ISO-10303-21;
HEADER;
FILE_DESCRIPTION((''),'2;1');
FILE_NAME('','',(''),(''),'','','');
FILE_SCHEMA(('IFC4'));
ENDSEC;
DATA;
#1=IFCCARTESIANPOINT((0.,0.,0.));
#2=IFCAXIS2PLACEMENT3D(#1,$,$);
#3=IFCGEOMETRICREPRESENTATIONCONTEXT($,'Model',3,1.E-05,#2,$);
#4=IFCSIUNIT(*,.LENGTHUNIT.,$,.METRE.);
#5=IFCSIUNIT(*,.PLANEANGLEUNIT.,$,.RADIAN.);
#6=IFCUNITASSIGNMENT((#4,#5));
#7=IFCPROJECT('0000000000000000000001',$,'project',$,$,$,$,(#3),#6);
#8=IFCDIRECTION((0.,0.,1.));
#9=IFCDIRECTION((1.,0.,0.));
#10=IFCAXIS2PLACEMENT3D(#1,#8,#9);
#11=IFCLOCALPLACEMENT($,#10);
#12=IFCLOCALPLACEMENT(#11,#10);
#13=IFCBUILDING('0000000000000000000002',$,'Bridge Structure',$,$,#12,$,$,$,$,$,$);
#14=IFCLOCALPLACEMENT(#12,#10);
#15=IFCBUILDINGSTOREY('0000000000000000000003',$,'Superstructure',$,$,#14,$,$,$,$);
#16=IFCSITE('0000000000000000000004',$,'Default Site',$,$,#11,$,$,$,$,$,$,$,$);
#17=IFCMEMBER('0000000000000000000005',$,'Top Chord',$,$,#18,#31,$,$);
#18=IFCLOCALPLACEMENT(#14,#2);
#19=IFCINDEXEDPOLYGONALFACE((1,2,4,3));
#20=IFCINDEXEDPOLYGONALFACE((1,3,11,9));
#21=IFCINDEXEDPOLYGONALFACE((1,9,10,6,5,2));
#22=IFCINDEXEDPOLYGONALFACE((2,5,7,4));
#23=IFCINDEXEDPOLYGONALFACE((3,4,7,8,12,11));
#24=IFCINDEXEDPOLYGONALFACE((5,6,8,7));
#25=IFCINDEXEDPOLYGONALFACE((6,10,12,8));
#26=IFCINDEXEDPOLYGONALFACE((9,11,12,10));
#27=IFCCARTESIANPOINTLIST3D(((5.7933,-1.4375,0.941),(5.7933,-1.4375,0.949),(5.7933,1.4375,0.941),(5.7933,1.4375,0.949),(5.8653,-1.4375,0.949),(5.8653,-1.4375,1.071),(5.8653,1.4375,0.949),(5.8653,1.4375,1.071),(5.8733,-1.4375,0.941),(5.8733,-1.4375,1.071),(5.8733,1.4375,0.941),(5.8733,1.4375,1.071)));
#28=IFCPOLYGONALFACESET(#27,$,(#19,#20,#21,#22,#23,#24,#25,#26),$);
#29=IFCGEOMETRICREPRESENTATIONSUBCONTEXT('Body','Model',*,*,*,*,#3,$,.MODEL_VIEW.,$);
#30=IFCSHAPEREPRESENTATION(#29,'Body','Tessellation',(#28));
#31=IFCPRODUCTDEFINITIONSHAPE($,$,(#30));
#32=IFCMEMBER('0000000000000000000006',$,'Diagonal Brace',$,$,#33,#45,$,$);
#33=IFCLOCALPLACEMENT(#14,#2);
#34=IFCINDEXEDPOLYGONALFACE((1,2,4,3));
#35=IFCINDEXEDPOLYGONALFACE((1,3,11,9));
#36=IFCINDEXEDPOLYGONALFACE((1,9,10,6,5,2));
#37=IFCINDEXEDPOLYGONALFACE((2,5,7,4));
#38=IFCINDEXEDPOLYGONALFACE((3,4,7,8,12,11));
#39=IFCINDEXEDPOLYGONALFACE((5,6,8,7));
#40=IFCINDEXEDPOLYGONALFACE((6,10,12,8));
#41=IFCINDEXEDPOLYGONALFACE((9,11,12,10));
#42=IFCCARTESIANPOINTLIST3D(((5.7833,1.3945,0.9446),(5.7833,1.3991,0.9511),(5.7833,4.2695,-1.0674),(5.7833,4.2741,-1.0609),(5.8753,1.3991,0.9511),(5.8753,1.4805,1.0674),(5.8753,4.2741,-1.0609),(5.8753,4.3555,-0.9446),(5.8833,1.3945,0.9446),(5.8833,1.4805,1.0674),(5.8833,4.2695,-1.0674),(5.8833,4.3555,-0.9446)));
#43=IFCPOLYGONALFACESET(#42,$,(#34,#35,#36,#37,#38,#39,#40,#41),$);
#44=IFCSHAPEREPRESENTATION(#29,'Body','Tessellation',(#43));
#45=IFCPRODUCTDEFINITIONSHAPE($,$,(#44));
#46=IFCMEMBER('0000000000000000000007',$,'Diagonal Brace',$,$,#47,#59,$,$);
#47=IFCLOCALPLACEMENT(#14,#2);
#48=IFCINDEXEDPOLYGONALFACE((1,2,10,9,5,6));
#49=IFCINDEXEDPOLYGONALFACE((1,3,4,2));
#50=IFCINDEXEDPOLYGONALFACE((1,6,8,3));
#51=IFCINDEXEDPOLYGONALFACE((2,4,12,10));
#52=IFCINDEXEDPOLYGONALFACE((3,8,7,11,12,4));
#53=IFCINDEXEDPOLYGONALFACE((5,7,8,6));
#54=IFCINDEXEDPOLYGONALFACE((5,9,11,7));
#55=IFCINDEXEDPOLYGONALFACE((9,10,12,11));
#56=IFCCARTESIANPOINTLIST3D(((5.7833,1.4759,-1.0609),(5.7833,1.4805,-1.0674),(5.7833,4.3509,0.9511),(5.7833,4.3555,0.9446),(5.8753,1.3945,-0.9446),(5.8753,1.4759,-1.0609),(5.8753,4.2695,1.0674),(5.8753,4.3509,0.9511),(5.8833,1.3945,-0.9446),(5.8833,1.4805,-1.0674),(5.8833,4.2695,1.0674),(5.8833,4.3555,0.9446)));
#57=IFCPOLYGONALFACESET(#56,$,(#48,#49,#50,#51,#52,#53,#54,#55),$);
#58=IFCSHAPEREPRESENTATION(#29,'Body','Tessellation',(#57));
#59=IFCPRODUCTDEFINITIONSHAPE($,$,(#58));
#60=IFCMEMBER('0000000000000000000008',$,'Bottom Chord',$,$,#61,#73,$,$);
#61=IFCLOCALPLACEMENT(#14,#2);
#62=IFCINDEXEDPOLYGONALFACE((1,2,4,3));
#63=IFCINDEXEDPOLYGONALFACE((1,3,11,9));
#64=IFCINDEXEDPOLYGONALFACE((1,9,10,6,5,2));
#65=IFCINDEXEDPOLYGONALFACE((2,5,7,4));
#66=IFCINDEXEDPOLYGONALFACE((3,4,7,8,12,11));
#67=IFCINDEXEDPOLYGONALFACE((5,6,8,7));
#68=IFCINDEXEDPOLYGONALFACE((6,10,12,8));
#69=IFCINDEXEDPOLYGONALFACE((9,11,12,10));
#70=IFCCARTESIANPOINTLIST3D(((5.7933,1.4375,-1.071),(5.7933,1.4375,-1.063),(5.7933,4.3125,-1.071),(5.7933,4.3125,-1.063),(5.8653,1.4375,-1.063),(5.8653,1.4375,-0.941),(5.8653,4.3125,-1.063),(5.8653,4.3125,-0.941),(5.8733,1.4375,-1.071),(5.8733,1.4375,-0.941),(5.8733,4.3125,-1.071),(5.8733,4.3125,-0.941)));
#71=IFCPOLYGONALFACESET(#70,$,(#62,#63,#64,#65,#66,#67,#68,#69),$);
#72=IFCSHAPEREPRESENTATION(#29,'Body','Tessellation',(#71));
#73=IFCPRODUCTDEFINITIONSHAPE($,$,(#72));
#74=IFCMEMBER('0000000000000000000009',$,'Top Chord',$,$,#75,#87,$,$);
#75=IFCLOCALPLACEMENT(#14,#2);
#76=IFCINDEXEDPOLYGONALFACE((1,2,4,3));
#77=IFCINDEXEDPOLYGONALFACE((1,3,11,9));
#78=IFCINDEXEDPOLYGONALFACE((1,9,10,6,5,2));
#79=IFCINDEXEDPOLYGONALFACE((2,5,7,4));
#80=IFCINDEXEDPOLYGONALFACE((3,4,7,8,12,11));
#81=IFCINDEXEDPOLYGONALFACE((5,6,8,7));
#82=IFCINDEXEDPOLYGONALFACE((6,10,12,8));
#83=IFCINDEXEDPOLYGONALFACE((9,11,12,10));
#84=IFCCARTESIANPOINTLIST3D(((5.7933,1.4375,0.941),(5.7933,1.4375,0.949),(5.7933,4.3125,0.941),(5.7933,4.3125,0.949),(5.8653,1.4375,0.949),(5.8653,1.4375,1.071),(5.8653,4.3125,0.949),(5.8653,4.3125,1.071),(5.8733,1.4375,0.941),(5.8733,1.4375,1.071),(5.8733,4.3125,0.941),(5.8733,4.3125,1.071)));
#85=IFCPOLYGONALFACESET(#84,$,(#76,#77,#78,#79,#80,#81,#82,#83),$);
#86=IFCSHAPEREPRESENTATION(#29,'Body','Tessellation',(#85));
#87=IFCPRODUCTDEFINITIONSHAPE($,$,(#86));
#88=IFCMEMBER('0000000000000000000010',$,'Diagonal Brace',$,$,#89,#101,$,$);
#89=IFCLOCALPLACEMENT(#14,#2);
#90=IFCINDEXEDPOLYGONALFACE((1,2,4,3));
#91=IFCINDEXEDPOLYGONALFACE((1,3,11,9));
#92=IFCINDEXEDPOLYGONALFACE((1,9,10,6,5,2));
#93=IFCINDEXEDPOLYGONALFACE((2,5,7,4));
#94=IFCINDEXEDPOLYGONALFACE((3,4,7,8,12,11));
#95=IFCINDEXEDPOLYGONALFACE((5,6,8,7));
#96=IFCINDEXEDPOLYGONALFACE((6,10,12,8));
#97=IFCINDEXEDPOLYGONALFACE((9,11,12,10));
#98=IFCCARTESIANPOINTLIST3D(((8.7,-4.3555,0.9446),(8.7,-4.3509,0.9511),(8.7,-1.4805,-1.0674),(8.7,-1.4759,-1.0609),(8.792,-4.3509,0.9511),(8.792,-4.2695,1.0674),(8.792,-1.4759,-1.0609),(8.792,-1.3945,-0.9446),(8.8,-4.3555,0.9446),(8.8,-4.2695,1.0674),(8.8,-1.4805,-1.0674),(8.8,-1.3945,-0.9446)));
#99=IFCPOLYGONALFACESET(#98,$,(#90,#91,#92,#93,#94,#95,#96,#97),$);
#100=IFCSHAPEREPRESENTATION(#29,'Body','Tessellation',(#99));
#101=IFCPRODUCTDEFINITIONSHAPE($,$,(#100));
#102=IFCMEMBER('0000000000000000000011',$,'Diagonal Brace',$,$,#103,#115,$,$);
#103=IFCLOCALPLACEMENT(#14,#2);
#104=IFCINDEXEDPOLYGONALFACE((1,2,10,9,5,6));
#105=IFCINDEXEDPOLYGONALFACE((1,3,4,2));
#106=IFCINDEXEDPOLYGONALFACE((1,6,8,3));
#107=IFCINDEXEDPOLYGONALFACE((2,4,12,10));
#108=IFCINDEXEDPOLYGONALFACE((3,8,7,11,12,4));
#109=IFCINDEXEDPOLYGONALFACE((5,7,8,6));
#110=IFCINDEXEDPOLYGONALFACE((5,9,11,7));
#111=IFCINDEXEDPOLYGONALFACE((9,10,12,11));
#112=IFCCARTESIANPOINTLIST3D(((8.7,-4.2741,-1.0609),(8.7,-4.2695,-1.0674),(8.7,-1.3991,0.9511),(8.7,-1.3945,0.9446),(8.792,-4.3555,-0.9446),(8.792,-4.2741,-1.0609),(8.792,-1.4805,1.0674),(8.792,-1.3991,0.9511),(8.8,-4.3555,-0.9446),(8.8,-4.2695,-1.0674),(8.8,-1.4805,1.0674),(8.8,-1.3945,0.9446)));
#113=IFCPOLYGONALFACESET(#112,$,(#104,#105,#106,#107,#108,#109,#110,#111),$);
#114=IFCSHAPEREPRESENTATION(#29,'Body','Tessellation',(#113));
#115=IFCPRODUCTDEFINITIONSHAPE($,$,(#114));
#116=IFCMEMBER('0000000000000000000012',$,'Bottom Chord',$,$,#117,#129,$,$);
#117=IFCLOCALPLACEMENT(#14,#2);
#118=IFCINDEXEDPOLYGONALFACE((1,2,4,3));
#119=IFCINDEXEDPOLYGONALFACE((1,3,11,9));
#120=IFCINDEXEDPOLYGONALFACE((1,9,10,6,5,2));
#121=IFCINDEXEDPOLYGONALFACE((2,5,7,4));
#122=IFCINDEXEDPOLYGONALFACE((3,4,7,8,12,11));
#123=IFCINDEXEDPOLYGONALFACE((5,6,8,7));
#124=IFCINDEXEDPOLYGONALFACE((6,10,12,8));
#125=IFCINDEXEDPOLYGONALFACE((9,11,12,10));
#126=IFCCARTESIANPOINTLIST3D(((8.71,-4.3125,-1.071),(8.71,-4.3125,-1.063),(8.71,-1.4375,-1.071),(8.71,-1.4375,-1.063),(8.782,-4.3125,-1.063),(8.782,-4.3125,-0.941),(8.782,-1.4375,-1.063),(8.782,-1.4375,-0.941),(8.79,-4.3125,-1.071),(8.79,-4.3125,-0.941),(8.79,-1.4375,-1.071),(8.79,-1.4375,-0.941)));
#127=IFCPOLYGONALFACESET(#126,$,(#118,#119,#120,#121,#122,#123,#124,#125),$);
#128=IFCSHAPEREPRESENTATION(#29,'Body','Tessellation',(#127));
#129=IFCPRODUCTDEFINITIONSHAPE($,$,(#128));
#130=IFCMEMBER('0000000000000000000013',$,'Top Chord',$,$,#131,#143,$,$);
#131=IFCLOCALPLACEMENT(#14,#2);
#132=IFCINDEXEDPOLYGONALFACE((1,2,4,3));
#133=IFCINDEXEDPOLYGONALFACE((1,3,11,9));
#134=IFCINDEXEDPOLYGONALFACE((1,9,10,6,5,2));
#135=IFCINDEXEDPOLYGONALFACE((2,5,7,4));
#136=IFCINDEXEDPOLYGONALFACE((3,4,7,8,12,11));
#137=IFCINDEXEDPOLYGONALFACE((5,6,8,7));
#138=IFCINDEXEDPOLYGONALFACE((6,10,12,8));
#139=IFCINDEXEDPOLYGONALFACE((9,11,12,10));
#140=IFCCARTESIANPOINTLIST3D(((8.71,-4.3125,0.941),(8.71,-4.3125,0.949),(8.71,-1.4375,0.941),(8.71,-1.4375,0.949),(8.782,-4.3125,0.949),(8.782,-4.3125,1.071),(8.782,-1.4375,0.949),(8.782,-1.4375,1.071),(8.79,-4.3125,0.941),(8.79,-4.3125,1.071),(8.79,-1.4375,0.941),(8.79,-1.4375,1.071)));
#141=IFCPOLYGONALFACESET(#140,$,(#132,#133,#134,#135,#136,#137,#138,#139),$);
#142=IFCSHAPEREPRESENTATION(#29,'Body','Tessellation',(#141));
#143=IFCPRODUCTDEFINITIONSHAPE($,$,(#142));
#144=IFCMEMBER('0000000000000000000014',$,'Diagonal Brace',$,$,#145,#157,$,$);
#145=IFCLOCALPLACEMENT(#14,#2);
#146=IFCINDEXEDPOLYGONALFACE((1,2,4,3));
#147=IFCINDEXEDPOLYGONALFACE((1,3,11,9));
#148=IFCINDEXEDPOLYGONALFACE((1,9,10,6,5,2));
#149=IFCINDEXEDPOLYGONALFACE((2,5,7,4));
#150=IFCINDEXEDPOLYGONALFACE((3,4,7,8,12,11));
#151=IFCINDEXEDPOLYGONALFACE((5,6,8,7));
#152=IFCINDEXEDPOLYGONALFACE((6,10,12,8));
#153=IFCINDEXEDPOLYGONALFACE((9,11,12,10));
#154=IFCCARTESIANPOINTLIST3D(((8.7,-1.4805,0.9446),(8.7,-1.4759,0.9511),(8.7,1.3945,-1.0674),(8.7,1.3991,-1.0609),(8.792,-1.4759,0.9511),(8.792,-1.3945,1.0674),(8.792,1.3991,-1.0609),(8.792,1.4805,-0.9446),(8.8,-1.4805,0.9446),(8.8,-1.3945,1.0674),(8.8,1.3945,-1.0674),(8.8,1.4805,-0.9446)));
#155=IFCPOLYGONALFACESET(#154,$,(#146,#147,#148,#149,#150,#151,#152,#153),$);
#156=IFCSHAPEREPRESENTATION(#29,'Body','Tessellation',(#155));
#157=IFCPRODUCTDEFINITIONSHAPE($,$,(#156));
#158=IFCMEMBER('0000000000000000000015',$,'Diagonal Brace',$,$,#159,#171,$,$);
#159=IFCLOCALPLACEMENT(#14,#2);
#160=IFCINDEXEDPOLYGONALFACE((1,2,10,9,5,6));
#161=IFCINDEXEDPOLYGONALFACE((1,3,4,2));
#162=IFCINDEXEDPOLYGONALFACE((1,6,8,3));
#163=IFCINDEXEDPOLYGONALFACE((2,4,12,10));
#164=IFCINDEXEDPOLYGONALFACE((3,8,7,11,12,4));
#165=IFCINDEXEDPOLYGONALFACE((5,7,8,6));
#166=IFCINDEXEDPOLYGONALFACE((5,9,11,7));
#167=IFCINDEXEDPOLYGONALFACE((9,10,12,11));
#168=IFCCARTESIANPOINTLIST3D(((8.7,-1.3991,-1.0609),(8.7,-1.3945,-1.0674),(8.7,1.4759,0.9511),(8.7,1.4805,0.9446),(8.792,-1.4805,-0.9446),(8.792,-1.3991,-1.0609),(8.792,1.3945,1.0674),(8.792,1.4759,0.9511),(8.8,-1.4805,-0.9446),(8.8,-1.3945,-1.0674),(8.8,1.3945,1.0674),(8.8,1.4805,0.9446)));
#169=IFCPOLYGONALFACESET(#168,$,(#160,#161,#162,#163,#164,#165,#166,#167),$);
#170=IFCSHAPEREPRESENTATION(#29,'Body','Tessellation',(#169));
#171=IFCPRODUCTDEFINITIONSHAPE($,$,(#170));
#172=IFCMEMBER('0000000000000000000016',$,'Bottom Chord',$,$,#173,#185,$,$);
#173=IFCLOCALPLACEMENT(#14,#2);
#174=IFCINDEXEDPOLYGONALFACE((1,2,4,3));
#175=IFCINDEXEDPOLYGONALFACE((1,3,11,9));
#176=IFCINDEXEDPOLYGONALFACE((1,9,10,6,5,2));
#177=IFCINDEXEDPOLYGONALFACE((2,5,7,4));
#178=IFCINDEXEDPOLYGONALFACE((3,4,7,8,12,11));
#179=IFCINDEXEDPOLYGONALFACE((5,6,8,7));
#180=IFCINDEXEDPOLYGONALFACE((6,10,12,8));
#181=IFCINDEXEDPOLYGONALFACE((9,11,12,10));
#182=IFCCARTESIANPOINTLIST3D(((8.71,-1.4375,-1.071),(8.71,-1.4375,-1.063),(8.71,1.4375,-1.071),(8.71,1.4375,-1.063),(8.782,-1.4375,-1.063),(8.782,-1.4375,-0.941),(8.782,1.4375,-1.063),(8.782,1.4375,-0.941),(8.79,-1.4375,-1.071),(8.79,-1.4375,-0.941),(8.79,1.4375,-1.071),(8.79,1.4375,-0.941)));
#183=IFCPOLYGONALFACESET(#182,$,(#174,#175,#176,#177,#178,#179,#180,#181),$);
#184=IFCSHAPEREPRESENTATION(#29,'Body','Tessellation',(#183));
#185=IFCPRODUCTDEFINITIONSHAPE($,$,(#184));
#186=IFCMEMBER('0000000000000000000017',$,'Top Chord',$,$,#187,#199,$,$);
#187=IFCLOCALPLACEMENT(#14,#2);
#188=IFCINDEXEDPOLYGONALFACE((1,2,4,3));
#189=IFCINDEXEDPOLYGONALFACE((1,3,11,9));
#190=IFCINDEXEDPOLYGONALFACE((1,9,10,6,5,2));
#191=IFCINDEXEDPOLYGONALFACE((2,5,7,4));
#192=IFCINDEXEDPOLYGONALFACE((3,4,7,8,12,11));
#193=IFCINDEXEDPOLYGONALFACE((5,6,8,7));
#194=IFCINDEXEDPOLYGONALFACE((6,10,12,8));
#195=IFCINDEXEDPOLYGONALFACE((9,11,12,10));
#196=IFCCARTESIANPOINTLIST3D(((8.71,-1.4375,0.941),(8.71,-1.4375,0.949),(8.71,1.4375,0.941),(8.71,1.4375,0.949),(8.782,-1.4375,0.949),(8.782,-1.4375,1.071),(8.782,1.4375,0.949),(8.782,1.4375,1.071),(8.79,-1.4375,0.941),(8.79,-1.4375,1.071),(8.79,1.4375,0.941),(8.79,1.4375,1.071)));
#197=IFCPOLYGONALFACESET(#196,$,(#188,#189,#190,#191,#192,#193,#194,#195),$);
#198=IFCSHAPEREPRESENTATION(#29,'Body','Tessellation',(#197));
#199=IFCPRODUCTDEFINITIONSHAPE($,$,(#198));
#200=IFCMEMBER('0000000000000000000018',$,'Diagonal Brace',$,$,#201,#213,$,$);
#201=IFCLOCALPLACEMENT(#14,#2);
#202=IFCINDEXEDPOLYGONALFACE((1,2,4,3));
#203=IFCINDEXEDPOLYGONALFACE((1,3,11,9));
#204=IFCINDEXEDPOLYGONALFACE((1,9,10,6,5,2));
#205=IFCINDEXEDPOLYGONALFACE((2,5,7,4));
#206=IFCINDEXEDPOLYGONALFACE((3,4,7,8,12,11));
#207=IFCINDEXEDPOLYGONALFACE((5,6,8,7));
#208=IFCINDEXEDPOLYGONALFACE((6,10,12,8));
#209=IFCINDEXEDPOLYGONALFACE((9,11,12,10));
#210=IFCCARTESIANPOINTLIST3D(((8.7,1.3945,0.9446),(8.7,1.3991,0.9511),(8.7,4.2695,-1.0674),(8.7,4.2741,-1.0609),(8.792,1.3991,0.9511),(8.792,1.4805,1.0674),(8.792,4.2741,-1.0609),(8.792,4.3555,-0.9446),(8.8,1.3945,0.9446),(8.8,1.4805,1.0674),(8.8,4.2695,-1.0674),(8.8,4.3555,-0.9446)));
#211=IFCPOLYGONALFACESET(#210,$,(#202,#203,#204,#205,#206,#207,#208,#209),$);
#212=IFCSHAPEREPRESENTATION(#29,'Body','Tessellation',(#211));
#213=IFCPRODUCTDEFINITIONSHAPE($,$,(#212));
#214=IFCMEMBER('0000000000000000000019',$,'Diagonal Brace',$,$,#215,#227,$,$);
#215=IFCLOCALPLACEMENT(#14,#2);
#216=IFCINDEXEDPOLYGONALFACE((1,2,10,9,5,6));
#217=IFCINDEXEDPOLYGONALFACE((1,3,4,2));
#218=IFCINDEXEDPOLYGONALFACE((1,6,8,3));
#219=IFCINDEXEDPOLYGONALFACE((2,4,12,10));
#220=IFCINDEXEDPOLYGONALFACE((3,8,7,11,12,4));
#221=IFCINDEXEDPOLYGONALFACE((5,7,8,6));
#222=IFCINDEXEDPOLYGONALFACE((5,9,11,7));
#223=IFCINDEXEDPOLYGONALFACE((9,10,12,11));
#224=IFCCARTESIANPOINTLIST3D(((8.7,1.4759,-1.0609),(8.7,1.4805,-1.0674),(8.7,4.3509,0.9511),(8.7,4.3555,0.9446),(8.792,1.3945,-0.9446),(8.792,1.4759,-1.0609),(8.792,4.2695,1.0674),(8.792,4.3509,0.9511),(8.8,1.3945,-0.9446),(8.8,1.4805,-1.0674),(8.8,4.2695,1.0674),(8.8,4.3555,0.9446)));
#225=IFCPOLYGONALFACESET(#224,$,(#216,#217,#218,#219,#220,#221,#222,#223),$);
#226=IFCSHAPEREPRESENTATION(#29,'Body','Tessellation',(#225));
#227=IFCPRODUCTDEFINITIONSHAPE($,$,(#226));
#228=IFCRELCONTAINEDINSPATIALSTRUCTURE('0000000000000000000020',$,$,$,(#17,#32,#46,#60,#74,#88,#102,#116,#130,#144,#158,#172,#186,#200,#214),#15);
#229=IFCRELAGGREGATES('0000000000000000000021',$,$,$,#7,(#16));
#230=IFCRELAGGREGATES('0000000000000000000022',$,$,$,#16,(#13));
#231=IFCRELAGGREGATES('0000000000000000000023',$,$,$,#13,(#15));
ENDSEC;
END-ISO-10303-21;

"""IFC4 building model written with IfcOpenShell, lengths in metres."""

from ifc_helpers import new_model, si_unit, frame, origin, origin_with_axes, origin_2d_with_axis, place, context, subcontext, project, spatial, l_section, extrude, element, save


model = new_model("IFC4")

# Units and contexts
model_context = context("Model", 3, precision=1e-05, world=origin())
body_context = subcontext(model_context, "Body", "Model", "MODEL_VIEW")
ifc_project = project(units=[si_unit("LENGTHUNIT", "METRE"), si_unit("PLANEANGLEUNIT", "RADIAN")], contexts=[model_context])

# Site, building, storey
site_placement = place(None, origin_with_axes())
site = spatial("IfcSite", under=ifc_project, at=site_placement, Name="Default Site")
building_placement = place(site_placement, origin_with_axes())
building = spatial("IfcBuilding", under=site, at=building_placement, Name="Bridge Structure")
storey_placement = place(building_placement, origin_with_axes())
storey = spatial("IfcBuildingStorey", under=building, at=storey_placement, Name="Superstructure")

# Members
member_1_placement = place(storey_placement, frame((5.8333, -1.4375, 1.006), z_axis=(0.0, 1.0, 0.0), x_axis=(-1.0, 0.0, 0.0)))
element("IfcMember", 1, at=member_1_placement, inside=storey, Name="Top Chord", context=body_context, shape_type="SweptSolid", body=[
    extrude(l_section(Depth=0.13, Width=0.08, Thickness=0.008, at=origin_2d_with_axis()), origin_with_axes(), (0.0, 0.0, 1.0), 2.875),
])
for number, where, z_axis, x_axis, name in (
    (2, (5.8333, 1.4375, 1.006), (0.0, 0.819299, -0.573367), (-1.0, 0.0, 0.0), "Diagonal Brace"),
    (3, (5.8333, 1.4375, -1.006), (0.0, 0.819299, 0.573367), (-1.0, 0.0, 0.0), "Diagonal Brace"),
):
    element("IfcMember", number, at=place(storey_placement, frame(where, z_axis=z_axis, x_axis=x_axis)), inside=storey, Name=name, context=body_context, shape_type="SweptSolid", body=[
        extrude(l_section(Depth=0.15, Width=0.1, Thickness=0.008, at=origin_2d_with_axis()), origin_with_axes(), (0.0, 0.0, 1.0), 3.5091),
    ])
for number, where, z_axis, x_axis, name in (
    (4, (5.8333, 1.4375, -1.006), (0.0, 1.0, 0.0), (-1.0, 0.0, 0.0), "Bottom Chord"),
    (5, (5.8333, 1.4375, 1.006), (0.0, 1.0, 0.0), (-1.0, 0.0, 0.0), "Top Chord"),
):
    element("IfcMember", number, at=place(storey_placement, frame(where, z_axis=z_axis, x_axis=x_axis)), inside=storey, Name=name, context=body_context, shape_type="SweptSolid", body=[
        extrude(l_section(Depth=0.13, Width=0.08, Thickness=0.008, at=origin_2d_with_axis()), origin_with_axes(), (0.0, 0.0, 1.0), 2.875),
    ])
for number, where, z_axis, x_axis, name in (
    (6, (8.75, -4.3125, 1.006), (0.0, 0.819299, -0.573367), (-1.0, 0.0, 0.0), "Diagonal Brace"),
    (7, (8.75, -4.3125, -1.006), (0.0, 0.819299, 0.573367), (-1.0, 0.0, 0.0), "Diagonal Brace"),
):
    element("IfcMember", number, at=place(storey_placement, frame(where, z_axis=z_axis, x_axis=x_axis)), inside=storey, Name=name, context=body_context, shape_type="SweptSolid", body=[
        extrude(l_section(Depth=0.15, Width=0.1, Thickness=0.008, at=origin_2d_with_axis()), origin_with_axes(), (0.0, 0.0, 1.0), 3.5091),
    ])
for number, where, z_axis, x_axis, name in (
    (8, (8.75, -4.3125, -1.006), (0.0, 1.0, 0.0), (-1.0, 0.0, 0.0), "Bottom Chord"),
    (9, (8.75, -4.3125, 1.006), (0.0, 1.0, 0.0), (-1.0, 0.0, 0.0), "Top Chord"),
):
    element("IfcMember", number, at=place(storey_placement, frame(where, z_axis=z_axis, x_axis=x_axis)), inside=storey, Name=name, context=body_context, shape_type="SweptSolid", body=[
        extrude(l_section(Depth=0.13, Width=0.08, Thickness=0.008, at=origin_2d_with_axis()), origin_with_axes(), (0.0, 0.0, 1.0), 2.875),
    ])
for number, where, z_axis, x_axis, name in (
    (10, (8.75, -1.4375, 1.006), (0.0, 0.819299, -0.573367), (-1.0, 0.0, 0.0), "Diagonal Brace"),
    (11, (8.75, -1.4375, -1.006), (0.0, 0.819299, 0.573367), (-1.0, 0.0, 0.0), "Diagonal Brace"),
):
    element("IfcMember", number, at=place(storey_placement, frame(where, z_axis=z_axis, x_axis=x_axis)), inside=storey, Name=name, context=body_context, shape_type="SweptSolid", body=[
        extrude(l_section(Depth=0.15, Width=0.1, Thickness=0.008, at=origin_2d_with_axis()), origin_with_axes(), (0.0, 0.0, 1.0), 3.5091),
    ])
for number, where, z_axis, x_axis, name in (
    (12, (8.75, -1.4375, -1.006), (0.0, 1.0, 0.0), (-1.0, 0.0, 0.0), "Bottom Chord"),
    (13, (8.75, -1.4375, 1.006), (0.0, 1.0, 0.0), (-1.0, 0.0, 0.0), "Top Chord"),
):
    element("IfcMember", number, at=place(storey_placement, frame(where, z_axis=z_axis, x_axis=x_axis)), inside=storey, Name=name, context=body_context, shape_type="SweptSolid", body=[
        extrude(l_section(Depth=0.13, Width=0.08, Thickness=0.008, at=origin_2d_with_axis()), origin_with_axes(), (0.0, 0.0, 1.0), 2.875),
    ])
for number, where, z_axis, x_axis, name in (
    (14, (8.75, 1.4375, 1.006), (0.0, 0.819299, -0.573367), (-1.0, 0.0, 0.0), "Diagonal Brace"),
    (15, (8.75, 1.4375, -1.006), (0.0, 0.819299, 0.573367), (-1.0, 0.0, 0.0), "Diagonal Brace"),
):
    element("IfcMember", number, at=place(storey_placement, frame(where, z_axis=z_axis, x_axis=x_axis)), inside=storey, Name=name, context=body_context, shape_type="SweptSolid", body=[
        extrude(l_section(Depth=0.15, Width=0.1, Thickness=0.008, at=origin_2d_with_axis()), origin_with_axes(), (0.0, 0.0, 1.0), 3.5091),
    ])

save(model, "model.ifc")
